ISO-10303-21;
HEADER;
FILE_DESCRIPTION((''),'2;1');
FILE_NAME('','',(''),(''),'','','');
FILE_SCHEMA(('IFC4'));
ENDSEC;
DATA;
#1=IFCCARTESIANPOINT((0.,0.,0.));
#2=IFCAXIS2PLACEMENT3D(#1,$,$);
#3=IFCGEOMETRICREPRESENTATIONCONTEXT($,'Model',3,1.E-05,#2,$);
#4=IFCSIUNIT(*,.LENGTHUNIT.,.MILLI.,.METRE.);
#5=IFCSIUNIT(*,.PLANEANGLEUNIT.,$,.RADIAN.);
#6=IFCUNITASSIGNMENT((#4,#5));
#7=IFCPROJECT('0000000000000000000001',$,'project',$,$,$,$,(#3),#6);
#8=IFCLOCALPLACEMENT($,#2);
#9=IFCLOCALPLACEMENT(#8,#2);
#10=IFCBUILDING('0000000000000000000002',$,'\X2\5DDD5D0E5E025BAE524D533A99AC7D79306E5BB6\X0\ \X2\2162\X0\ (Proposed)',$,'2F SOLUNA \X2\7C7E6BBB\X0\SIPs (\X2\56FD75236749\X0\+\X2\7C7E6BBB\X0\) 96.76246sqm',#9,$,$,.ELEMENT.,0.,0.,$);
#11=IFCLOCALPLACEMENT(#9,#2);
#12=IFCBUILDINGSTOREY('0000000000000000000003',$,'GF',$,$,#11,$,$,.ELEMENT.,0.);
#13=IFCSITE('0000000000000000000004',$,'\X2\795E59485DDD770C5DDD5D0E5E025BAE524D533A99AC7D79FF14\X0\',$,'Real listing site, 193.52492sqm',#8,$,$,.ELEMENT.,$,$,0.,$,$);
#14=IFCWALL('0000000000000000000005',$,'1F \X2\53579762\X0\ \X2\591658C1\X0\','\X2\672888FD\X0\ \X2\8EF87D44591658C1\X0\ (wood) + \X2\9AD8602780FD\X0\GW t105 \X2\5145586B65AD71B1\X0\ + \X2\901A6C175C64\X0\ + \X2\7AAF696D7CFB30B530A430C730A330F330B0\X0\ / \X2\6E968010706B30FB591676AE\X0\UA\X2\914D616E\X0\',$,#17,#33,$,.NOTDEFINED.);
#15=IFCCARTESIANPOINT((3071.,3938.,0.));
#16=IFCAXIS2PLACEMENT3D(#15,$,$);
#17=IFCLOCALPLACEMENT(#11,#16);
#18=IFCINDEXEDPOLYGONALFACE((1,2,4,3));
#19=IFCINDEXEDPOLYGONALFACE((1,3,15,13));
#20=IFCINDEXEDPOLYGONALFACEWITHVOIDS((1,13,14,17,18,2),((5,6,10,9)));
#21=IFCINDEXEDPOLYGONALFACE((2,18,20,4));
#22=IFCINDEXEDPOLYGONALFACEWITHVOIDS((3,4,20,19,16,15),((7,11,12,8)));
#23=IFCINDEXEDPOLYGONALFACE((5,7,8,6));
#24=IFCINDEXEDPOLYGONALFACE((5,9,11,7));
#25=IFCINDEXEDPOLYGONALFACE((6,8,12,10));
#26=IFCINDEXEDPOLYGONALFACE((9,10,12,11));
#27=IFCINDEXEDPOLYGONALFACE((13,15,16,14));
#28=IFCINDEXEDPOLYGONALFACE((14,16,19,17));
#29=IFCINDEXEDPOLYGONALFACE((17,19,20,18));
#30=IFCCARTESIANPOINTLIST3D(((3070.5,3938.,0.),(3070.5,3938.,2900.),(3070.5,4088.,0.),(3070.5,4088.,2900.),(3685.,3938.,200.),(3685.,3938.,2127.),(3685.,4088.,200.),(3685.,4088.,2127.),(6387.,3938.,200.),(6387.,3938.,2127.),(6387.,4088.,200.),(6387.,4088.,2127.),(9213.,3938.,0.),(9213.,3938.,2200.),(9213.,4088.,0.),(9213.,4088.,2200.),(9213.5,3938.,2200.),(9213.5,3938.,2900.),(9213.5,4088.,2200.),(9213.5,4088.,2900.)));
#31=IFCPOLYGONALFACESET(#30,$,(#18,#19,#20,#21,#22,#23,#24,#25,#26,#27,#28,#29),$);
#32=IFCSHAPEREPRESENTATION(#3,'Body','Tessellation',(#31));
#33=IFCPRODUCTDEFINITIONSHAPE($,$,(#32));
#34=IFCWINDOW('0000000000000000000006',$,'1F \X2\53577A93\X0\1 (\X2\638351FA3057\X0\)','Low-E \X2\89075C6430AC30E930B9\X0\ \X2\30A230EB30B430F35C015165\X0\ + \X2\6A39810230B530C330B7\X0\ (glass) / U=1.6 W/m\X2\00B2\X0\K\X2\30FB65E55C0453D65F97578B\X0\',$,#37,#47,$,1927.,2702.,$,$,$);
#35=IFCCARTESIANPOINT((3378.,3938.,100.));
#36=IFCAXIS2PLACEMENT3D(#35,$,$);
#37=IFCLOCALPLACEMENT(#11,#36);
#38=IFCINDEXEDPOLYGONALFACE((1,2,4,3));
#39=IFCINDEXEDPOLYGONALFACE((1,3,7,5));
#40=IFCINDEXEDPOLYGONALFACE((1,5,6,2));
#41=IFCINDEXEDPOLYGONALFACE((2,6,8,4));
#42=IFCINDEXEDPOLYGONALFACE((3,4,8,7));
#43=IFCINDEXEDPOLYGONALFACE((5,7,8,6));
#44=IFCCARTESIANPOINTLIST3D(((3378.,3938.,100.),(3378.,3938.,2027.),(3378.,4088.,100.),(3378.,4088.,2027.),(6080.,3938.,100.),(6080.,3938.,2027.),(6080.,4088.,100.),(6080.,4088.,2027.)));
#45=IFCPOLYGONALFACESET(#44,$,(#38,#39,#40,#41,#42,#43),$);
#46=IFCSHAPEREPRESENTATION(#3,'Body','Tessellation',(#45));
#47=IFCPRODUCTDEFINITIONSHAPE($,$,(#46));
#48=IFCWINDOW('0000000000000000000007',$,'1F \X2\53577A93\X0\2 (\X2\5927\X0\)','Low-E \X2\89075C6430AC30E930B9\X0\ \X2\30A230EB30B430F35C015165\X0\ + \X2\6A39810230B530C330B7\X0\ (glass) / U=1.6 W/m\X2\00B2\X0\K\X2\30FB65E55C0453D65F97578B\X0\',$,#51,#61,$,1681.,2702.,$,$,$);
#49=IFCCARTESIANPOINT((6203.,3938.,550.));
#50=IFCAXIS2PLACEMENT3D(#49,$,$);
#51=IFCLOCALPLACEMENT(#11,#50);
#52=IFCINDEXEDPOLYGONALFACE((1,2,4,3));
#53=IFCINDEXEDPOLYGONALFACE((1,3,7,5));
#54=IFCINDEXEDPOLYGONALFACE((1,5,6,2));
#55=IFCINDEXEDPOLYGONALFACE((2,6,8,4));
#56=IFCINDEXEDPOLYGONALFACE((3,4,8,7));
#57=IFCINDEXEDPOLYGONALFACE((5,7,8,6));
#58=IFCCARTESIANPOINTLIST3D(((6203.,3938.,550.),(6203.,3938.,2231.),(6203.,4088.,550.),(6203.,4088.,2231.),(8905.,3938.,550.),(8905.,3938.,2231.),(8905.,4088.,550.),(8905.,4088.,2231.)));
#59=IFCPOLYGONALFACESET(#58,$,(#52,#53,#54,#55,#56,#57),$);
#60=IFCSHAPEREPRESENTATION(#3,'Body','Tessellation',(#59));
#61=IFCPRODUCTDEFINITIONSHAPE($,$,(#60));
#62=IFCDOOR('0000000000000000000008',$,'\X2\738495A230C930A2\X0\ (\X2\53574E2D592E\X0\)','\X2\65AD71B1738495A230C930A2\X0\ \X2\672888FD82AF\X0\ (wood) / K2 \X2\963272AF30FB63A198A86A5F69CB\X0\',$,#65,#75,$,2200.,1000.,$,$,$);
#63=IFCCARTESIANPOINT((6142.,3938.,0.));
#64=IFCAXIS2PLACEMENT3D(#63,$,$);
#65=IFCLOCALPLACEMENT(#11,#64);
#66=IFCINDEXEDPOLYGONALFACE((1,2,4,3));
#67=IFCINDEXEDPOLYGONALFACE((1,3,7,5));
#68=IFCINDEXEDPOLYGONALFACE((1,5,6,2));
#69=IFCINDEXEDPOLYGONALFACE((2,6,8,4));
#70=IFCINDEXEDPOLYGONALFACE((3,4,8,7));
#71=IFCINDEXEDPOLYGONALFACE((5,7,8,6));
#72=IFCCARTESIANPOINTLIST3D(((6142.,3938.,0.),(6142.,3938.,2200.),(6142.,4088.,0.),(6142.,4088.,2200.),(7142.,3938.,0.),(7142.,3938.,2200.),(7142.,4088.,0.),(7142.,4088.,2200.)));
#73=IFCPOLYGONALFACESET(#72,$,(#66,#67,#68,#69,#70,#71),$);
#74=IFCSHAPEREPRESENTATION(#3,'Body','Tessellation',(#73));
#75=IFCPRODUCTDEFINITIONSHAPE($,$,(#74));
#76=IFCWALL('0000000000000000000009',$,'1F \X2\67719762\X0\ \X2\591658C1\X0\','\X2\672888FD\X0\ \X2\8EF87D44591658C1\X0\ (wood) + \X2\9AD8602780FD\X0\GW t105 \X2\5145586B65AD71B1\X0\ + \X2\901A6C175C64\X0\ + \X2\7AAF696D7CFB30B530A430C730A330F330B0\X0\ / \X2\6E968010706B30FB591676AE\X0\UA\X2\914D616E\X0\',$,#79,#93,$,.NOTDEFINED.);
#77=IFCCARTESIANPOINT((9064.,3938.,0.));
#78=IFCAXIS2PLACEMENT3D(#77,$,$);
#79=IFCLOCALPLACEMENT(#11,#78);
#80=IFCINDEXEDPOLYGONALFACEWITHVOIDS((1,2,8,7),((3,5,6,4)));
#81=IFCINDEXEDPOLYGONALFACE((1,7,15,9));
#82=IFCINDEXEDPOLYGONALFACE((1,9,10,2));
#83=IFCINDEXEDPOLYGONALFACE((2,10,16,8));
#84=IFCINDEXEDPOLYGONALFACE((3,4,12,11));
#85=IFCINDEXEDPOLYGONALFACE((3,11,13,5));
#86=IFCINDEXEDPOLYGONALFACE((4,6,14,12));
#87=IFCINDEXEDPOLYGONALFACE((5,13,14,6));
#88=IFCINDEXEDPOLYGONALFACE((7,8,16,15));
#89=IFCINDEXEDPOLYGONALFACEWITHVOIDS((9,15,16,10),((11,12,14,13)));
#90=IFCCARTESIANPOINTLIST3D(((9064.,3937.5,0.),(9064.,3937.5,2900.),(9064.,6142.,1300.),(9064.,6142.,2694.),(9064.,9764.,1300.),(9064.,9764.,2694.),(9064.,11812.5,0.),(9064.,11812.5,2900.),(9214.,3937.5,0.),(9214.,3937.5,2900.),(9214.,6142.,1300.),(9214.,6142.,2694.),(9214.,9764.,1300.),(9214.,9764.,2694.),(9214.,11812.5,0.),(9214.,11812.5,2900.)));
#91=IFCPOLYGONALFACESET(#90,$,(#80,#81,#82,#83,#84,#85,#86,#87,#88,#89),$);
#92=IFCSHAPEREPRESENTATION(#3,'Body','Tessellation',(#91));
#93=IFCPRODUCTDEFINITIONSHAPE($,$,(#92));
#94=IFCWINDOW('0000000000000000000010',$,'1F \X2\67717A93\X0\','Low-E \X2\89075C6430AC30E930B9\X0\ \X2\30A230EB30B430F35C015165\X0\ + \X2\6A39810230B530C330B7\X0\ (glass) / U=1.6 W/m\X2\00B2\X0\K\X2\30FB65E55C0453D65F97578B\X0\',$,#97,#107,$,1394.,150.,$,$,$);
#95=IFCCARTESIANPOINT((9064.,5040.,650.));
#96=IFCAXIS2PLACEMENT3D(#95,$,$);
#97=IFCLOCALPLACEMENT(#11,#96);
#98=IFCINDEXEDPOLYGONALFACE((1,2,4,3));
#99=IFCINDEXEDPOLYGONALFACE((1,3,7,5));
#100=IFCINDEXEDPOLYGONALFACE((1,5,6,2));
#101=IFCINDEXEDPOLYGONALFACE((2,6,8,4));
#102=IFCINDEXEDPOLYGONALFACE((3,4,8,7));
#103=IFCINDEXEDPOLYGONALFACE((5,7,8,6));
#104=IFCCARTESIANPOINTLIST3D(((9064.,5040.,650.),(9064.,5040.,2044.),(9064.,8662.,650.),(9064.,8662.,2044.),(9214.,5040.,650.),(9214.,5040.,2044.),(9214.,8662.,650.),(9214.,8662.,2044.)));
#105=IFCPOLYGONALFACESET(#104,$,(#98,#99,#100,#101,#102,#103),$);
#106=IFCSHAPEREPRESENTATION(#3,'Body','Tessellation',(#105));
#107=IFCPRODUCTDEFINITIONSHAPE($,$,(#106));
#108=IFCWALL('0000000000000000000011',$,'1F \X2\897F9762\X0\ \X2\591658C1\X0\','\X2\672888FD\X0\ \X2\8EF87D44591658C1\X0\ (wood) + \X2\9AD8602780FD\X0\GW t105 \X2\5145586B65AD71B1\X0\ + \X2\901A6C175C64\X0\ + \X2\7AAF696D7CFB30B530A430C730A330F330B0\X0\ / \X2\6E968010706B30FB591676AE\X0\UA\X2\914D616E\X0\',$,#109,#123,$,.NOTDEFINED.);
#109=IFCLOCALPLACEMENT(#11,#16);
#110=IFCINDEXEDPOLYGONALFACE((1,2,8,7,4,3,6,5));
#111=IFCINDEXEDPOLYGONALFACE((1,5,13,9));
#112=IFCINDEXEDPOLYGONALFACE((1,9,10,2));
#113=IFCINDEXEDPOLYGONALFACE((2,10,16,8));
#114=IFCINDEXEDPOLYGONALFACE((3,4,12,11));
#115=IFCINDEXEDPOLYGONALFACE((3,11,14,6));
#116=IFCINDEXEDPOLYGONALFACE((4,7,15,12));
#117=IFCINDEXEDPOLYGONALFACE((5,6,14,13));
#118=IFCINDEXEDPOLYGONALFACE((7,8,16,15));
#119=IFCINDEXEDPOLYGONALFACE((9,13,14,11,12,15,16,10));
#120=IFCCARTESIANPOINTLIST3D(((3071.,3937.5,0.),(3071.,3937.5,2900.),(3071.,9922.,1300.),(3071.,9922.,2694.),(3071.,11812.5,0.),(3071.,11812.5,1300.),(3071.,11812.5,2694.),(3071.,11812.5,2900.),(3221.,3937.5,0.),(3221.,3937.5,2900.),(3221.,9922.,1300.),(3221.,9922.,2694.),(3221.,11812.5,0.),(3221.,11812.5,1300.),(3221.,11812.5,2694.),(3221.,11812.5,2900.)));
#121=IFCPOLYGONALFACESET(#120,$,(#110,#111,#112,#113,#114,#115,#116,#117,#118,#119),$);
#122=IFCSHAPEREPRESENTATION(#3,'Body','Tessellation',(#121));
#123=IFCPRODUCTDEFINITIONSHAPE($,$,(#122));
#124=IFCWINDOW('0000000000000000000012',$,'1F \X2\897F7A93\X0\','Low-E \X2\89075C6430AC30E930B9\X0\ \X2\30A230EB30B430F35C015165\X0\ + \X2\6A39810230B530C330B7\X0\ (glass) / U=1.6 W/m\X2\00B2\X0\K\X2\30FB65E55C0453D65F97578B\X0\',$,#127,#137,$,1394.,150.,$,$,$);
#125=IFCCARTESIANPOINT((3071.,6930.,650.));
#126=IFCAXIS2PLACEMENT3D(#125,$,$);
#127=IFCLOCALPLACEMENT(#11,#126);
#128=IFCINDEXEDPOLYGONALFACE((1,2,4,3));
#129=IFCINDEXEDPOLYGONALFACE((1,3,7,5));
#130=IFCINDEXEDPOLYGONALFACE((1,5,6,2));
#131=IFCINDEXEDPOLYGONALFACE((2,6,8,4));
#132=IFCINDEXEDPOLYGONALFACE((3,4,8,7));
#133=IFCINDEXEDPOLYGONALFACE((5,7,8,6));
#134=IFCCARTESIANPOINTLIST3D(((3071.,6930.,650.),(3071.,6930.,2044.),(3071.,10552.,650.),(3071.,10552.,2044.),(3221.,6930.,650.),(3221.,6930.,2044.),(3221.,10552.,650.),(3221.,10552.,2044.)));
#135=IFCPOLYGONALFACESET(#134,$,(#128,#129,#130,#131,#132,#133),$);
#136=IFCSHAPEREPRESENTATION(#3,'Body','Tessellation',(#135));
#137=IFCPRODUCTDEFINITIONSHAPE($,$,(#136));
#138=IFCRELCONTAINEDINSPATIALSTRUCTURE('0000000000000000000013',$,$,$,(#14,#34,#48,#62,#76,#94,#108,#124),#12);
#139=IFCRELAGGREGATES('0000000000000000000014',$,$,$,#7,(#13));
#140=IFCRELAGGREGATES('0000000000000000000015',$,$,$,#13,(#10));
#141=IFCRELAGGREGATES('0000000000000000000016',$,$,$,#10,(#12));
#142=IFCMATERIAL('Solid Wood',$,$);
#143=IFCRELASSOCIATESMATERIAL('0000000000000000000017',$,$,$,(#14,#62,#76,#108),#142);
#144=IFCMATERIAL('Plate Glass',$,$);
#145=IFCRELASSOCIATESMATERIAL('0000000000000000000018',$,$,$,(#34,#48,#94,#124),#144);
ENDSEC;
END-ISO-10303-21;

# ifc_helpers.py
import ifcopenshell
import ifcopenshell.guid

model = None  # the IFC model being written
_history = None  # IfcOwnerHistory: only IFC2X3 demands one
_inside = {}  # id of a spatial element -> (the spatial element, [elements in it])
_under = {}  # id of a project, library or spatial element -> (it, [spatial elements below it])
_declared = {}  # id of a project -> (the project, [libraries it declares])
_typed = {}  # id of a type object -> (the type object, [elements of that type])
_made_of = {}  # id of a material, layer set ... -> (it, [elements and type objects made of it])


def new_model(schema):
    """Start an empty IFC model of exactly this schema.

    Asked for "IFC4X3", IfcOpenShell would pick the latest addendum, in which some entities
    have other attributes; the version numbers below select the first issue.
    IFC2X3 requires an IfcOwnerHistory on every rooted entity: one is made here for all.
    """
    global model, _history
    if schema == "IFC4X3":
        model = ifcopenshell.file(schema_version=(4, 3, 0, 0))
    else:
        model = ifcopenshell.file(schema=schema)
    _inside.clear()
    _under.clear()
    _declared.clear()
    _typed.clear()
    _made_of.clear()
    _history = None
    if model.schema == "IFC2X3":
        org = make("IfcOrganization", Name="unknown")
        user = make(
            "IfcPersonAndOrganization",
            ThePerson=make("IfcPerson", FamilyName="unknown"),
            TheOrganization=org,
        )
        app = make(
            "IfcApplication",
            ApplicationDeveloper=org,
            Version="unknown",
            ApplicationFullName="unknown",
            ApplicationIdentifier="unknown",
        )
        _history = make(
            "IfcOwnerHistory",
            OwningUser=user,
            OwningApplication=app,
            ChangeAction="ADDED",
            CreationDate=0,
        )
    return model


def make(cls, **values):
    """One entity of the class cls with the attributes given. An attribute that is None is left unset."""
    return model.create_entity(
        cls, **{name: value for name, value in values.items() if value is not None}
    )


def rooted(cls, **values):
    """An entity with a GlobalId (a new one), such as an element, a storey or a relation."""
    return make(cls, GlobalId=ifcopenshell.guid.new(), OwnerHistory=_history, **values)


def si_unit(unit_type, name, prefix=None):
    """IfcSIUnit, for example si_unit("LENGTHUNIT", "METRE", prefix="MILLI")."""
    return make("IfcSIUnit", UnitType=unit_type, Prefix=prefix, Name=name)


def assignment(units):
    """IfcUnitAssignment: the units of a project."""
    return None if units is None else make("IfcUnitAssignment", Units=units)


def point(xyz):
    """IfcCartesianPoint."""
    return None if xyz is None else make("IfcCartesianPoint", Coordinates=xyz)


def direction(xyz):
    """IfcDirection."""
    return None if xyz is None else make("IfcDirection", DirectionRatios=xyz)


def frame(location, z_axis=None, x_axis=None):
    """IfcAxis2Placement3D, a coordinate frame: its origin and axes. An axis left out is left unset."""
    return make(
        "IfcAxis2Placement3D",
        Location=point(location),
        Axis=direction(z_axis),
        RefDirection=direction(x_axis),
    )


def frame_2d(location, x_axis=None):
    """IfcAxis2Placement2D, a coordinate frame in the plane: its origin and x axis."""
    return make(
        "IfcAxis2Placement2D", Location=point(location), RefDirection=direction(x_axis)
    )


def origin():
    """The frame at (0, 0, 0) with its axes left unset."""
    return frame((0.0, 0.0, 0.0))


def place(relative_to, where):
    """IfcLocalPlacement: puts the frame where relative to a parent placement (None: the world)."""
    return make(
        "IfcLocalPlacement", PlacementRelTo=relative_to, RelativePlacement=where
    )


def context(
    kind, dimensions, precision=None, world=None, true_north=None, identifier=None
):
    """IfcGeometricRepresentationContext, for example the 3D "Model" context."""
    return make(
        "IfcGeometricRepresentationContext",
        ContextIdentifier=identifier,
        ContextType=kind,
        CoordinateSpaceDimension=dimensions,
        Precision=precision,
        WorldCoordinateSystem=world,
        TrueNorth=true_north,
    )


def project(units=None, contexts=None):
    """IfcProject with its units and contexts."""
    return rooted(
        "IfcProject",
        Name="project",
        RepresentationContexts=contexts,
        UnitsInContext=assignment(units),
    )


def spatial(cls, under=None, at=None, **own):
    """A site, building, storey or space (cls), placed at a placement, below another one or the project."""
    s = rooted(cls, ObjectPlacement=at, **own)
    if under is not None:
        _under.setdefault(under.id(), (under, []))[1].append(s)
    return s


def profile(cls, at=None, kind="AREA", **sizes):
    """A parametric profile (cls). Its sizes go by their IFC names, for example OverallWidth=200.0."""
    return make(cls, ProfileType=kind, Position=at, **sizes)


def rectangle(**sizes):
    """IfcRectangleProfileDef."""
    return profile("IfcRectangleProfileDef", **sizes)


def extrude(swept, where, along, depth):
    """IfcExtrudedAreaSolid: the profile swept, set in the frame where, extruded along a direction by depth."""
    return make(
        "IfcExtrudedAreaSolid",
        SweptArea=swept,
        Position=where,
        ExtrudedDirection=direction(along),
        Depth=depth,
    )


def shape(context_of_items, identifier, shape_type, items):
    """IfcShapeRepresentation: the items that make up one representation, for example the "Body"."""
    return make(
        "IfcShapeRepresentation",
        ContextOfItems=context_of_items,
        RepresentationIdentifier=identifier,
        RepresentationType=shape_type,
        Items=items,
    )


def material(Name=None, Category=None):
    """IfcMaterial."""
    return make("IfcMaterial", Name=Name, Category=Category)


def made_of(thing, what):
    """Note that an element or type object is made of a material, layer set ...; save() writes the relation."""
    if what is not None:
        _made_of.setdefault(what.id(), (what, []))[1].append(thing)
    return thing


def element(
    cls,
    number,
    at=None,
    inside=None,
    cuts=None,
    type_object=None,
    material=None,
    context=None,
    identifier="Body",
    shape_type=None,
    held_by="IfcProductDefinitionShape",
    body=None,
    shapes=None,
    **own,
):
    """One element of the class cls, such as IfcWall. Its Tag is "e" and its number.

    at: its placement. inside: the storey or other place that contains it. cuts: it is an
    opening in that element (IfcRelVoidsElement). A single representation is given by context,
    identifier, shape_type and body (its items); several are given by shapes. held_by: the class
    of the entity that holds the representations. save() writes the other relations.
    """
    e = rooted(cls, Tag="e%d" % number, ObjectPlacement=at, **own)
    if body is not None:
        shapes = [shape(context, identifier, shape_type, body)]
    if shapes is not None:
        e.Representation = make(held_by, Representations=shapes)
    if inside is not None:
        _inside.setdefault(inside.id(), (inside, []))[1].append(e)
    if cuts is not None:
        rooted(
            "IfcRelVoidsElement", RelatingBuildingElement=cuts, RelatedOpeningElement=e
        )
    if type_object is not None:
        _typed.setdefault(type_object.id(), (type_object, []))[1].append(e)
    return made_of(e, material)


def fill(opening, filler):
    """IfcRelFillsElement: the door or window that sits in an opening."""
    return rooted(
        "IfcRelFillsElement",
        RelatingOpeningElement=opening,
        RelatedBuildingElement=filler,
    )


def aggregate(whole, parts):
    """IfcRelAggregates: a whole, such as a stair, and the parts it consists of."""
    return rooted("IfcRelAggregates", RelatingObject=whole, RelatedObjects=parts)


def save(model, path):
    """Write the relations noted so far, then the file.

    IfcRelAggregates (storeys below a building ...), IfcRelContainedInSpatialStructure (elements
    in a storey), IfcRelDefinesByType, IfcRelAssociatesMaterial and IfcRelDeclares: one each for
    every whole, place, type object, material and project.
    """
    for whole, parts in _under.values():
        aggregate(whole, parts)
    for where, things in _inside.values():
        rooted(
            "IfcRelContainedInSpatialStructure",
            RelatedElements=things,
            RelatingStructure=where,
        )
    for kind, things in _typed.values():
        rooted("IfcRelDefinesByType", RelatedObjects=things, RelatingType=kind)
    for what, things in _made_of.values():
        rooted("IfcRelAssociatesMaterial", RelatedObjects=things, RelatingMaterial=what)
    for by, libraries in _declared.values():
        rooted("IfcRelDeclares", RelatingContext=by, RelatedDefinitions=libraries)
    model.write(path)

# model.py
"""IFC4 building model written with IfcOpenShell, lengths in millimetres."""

from ifc_helpers import new_model, si_unit, frame, frame_2d, origin, place, context, project, spatial, rectangle, extrude, material, element, fill, save


model = new_model("IFC4")

# Units and contexts
model_context = context("Model", 3, precision=1e-05, world=origin())
ifc_project = project(units=[si_unit("LENGTHUNIT", "METRE", prefix="MILLI"), si_unit("PLANEANGLEUNIT", "RADIAN")], contexts=[model_context])

# Site, building, storey
site_placement = place(None, origin())
site = spatial("IfcSite", under=ifc_project, at=site_placement, Name="神奈川県川崎市宮前区馬絹４", ObjectType="Real listing site, 193.52492sqm", CompositionType="ELEMENT", RefElevation=0.0)
building_placement = place(site_placement, origin())
building = spatial("IfcBuilding", under=site, at=building_placement, Name="川崎市宮前区馬絹の家 Ⅲ (Proposed)", ObjectType="2F SOLUNA 籾殻SIPs (国産杉+籾殻) 96.76246sqm", CompositionType="ELEMENT", ElevationOfRefHeight=0.0, ElevationOfTerrain=0.0)
storey_placement = place(building_placement, origin())
storey = spatial("IfcBuildingStorey", under=building, at=storey_placement, Name="GF", CompositionType="ELEMENT", Elevation=0.0)

# Shared definitions
ifc_material_1 = material(Name="Solid Wood")

# Wall, openings, windows, door
wall_1_placement = place(storey_placement, frame((3071.0, 3938.0, 0.0)))
wall_1 = element("IfcWall", 1, at=wall_1_placement, inside=storey, material=ifc_material_1, Name="1F 南面 外壁", Description="木製 軸組外壁 (wood) + 高性能GW t105 充填断熱 + 通気層 + 窯業系サイディング / 準耐火・外皮UA配慮", PredefinedType="NOTDEFINED", context=model_context, shape_type="SweptSolid", body=[
    extrude(rectangle(XDim=6143.0, YDim=150.0, at=frame_2d((3071.0, 75.0))), frame((3071.0, 3938.0, 0.0)), (0.0, 0.0, 1.0), 2900.0),
])
opening_1_placement = place(storey_placement, frame((3378.0, 3938.0, 100.0)))
opening_1 = element("IfcOpeningElement", 2, at=opening_1_placement, cuts=wall_1, PredefinedType="NOTDEFINED", context=model_context, shape_type="SweptSolid", body=[
    extrude(rectangle(XDim=2702.0, YDim=150.0, at=frame_2d((1351.0, 75.0))), frame((3378.0, 3938.0, 100.0)), (0.0, 0.0, 1.0), 1927.0),
])
opening_2_placement = place(storey_placement, frame((6203.0, 3938.0, 550.0)))
opening_2 = element("IfcOpeningElement", 3, at=opening_2_placement, cuts=wall_1, PredefinedType="NOTDEFINED", context=model_context, shape_type="SweptSolid", body=[
    extrude(rectangle(XDim=2702.0, YDim=150.0, at=frame_2d((1351.0, 75.0))), frame((6203.0, 3938.0, 550.0)), (0.0, 0.0, 1.0), 1681.0),
])
opening_3_placement = place(storey_placement, frame((6142.0, 3938.0, 0.0)))
opening_3 = element("IfcOpeningElement", 4, at=opening_3_placement, cuts=wall_1, PredefinedType="NOTDEFINED", context=model_context, shape_type="SweptSolid", body=[
    extrude(rectangle(XDim=1000.0, YDim=150.0, at=frame_2d((500.0, 75.0))), frame((6142.0, 3938.0, 0.0)), (0.0, 0.0, 1.0), 2200.0),
])
ifc_material_2 = material(Name="Plate Glass")
window_1_placement = place(storey_placement, frame((3378.0, 3938.0, 100.0)))
window_1 = element("IfcWindow", 5, at=window_1_placement, inside=storey, material=ifc_material_2, Name="1F 南窓1 (掃出し)", Description="Low-E 複層ガラス アルゴン封入 + 樹脂サッシ (glass) / U=1.6 W/m²K・日射取得型", OverallHeight=1927.0, OverallWidth=2702.0, context=model_context, shape_type="SweptSolid", body=[
    extrude(rectangle(XDim=2702.0, YDim=150.0, at=frame_2d((1351.0, 75.0))), frame((3378.0, 3938.0, 100.0)), (0.0, 0.0, 1.0), 1927.0),
])
fill(opening_1, window_1)
window_2_placement = place(storey_placement, frame((6203.0, 3938.0, 550.0)))
window_2 = element("IfcWindow", 6, at=window_2_placement, inside=storey, material=ifc_material_2, Name="1F 南窓2 (大)", Description="Low-E 複層ガラス アルゴン封入 + 樹脂サッシ (glass) / U=1.6 W/m²K・日射取得型", OverallHeight=1681.0, OverallWidth=2702.0, context=model_context, shape_type="SweptSolid", body=[
    extrude(rectangle(XDim=2702.0, YDim=150.0, at=frame_2d((1351.0, 75.0))), frame((6203.0, 3938.0, 550.0)), (0.0, 0.0, 1.0), 1681.0),
])
fill(opening_2, window_2)
door_placement = place(storey_placement, frame((6142.0, 3938.0, 0.0)))
door = element("IfcDoor", 7, at=door_placement, inside=storey, material=ifc_material_1, Name="玄関ドア (南中央)", Description="断熱玄関ドア 木製芯 (wood) / K2 防犯・採風機構", OverallHeight=2200.0, OverallWidth=1000.0, context=model_context, shape_type="SweptSolid", body=[
    extrude(rectangle(XDim=1000.0, YDim=150.0, at=frame_2d((500.0, 75.0))), frame((6142.0, 3938.0, 0.0)), (0.0, 0.0, 1.0), 2200.0),
])
fill(opening_3, door)

# Walls, openings, windows
wall_2_placement = place(storey_placement, frame((9064.0, 3938.0, 0.0)))
wall_2 = element("IfcWall", 8, at=wall_2_placement, inside=storey, material=ifc_material_1, Name="1F 東面 外壁", Description="木製 軸組外壁 (wood) + 高性能GW t105 充填断熱 + 通気層 + 窯業系サイディング / 準耐火・外皮UA配慮", PredefinedType="NOTDEFINED", context=model_context, shape_type="SweptSolid", body=[
    extrude(rectangle(XDim=150.0, YDim=7875.0, at=frame_2d((75.0, 3937.0))), frame((9064.0, 3938.0, 0.0)), (0.0, 0.0, 1.0), 2900.0),
])
opening_4_placement = place(storey_placement, frame((9064.0, 5040.0, 650.0)))
opening_4 = element("IfcOpeningElement", 9, at=opening_4_placement, cuts=wall_2, PredefinedType="NOTDEFINED", context=model_context, shape_type="SweptSolid", body=[
    extrude(rectangle(XDim=150.0, YDim=3622.0, at=frame_2d((75.0, 1811.0))), frame((9064.0, 5040.0, 650.0)), (0.0, 0.0, 1.0), 1394.0),
])
window_3_placement = place(storey_placement, frame((9064.0, 5040.0, 650.0)))
window_3 = element("IfcWindow", 10, at=window_3_placement, inside=storey, material=ifc_material_2, Name="1F 東窓", Description="Low-E 複層ガラス アルゴン封入 + 樹脂サッシ (glass) / U=1.6 W/m²K・日射取得型", OverallHeight=1394.0, OverallWidth=150.0, context=model_context, shape_type="SweptSolid", body=[
    extrude(rectangle(XDim=150.0, YDim=3622.0, at=frame_2d((75.0, 1811.0))), frame((9064.0, 5040.0, 650.0)), (0.0, 0.0, 1.0), 1394.0),
])
fill(opening_4, window_3)
wall_3_placement = place(storey_placement, frame((3071.0, 3938.0, 0.0)))
wall_3 = element("IfcWall", 11, at=wall_3_placement, inside=storey, material=ifc_material_1, Name="1F 西面 外壁", Description="木製 軸組外壁 (wood) + 高性能GW t105 充填断熱 + 通気層 + 窯業系サイディング / 準耐火・外皮UA配慮", PredefinedType="NOTDEFINED", context=model_context, shape_type="SweptSolid", body=[
    extrude(rectangle(XDim=150.0, YDim=7875.0, at=frame_2d((75.0, 3937.0))), frame((3071.0, 3938.0, 0.0)), (0.0, 0.0, 1.0), 2900.0),
])
opening_5_placement = place(storey_placement, frame((3071.0, 6930.0, 650.0)))
opening_5 = element("IfcOpeningElement", 12, at=opening_5_placement, cuts=wall_3, PredefinedType="NOTDEFINED", context=model_context, shape_type="SweptSolid", body=[
    extrude(rectangle(XDim=150.0, YDim=3622.0, at=frame_2d((75.0, 1811.0))), frame((3071.0, 6930.0, 650.0)), (0.0, 0.0, 1.0), 1394.0),
])
window_4_placement = place(storey_placement, frame((3071.0, 6930.0, 650.0)))
window_4 = element("IfcWindow", 13, at=window_4_placement, inside=storey, material=ifc_material_2, Name="1F 西窓", Description="Low-E 複層ガラス アルゴン封入 + 樹脂サッシ (glass) / U=1.6 W/m²K・日射取得型", OverallHeight=1394.0, OverallWidth=150.0, context=model_context, shape_type="SweptSolid", body=[
    extrude(rectangle(XDim=150.0, YDim=3622.0, at=frame_2d((75.0, 1811.0))), frame((3071.0, 6930.0, 650.0)), (0.0, 0.0, 1.0), 1394.0),
])
fill(opening_5, window_4)

save(model, "model.ifc")
